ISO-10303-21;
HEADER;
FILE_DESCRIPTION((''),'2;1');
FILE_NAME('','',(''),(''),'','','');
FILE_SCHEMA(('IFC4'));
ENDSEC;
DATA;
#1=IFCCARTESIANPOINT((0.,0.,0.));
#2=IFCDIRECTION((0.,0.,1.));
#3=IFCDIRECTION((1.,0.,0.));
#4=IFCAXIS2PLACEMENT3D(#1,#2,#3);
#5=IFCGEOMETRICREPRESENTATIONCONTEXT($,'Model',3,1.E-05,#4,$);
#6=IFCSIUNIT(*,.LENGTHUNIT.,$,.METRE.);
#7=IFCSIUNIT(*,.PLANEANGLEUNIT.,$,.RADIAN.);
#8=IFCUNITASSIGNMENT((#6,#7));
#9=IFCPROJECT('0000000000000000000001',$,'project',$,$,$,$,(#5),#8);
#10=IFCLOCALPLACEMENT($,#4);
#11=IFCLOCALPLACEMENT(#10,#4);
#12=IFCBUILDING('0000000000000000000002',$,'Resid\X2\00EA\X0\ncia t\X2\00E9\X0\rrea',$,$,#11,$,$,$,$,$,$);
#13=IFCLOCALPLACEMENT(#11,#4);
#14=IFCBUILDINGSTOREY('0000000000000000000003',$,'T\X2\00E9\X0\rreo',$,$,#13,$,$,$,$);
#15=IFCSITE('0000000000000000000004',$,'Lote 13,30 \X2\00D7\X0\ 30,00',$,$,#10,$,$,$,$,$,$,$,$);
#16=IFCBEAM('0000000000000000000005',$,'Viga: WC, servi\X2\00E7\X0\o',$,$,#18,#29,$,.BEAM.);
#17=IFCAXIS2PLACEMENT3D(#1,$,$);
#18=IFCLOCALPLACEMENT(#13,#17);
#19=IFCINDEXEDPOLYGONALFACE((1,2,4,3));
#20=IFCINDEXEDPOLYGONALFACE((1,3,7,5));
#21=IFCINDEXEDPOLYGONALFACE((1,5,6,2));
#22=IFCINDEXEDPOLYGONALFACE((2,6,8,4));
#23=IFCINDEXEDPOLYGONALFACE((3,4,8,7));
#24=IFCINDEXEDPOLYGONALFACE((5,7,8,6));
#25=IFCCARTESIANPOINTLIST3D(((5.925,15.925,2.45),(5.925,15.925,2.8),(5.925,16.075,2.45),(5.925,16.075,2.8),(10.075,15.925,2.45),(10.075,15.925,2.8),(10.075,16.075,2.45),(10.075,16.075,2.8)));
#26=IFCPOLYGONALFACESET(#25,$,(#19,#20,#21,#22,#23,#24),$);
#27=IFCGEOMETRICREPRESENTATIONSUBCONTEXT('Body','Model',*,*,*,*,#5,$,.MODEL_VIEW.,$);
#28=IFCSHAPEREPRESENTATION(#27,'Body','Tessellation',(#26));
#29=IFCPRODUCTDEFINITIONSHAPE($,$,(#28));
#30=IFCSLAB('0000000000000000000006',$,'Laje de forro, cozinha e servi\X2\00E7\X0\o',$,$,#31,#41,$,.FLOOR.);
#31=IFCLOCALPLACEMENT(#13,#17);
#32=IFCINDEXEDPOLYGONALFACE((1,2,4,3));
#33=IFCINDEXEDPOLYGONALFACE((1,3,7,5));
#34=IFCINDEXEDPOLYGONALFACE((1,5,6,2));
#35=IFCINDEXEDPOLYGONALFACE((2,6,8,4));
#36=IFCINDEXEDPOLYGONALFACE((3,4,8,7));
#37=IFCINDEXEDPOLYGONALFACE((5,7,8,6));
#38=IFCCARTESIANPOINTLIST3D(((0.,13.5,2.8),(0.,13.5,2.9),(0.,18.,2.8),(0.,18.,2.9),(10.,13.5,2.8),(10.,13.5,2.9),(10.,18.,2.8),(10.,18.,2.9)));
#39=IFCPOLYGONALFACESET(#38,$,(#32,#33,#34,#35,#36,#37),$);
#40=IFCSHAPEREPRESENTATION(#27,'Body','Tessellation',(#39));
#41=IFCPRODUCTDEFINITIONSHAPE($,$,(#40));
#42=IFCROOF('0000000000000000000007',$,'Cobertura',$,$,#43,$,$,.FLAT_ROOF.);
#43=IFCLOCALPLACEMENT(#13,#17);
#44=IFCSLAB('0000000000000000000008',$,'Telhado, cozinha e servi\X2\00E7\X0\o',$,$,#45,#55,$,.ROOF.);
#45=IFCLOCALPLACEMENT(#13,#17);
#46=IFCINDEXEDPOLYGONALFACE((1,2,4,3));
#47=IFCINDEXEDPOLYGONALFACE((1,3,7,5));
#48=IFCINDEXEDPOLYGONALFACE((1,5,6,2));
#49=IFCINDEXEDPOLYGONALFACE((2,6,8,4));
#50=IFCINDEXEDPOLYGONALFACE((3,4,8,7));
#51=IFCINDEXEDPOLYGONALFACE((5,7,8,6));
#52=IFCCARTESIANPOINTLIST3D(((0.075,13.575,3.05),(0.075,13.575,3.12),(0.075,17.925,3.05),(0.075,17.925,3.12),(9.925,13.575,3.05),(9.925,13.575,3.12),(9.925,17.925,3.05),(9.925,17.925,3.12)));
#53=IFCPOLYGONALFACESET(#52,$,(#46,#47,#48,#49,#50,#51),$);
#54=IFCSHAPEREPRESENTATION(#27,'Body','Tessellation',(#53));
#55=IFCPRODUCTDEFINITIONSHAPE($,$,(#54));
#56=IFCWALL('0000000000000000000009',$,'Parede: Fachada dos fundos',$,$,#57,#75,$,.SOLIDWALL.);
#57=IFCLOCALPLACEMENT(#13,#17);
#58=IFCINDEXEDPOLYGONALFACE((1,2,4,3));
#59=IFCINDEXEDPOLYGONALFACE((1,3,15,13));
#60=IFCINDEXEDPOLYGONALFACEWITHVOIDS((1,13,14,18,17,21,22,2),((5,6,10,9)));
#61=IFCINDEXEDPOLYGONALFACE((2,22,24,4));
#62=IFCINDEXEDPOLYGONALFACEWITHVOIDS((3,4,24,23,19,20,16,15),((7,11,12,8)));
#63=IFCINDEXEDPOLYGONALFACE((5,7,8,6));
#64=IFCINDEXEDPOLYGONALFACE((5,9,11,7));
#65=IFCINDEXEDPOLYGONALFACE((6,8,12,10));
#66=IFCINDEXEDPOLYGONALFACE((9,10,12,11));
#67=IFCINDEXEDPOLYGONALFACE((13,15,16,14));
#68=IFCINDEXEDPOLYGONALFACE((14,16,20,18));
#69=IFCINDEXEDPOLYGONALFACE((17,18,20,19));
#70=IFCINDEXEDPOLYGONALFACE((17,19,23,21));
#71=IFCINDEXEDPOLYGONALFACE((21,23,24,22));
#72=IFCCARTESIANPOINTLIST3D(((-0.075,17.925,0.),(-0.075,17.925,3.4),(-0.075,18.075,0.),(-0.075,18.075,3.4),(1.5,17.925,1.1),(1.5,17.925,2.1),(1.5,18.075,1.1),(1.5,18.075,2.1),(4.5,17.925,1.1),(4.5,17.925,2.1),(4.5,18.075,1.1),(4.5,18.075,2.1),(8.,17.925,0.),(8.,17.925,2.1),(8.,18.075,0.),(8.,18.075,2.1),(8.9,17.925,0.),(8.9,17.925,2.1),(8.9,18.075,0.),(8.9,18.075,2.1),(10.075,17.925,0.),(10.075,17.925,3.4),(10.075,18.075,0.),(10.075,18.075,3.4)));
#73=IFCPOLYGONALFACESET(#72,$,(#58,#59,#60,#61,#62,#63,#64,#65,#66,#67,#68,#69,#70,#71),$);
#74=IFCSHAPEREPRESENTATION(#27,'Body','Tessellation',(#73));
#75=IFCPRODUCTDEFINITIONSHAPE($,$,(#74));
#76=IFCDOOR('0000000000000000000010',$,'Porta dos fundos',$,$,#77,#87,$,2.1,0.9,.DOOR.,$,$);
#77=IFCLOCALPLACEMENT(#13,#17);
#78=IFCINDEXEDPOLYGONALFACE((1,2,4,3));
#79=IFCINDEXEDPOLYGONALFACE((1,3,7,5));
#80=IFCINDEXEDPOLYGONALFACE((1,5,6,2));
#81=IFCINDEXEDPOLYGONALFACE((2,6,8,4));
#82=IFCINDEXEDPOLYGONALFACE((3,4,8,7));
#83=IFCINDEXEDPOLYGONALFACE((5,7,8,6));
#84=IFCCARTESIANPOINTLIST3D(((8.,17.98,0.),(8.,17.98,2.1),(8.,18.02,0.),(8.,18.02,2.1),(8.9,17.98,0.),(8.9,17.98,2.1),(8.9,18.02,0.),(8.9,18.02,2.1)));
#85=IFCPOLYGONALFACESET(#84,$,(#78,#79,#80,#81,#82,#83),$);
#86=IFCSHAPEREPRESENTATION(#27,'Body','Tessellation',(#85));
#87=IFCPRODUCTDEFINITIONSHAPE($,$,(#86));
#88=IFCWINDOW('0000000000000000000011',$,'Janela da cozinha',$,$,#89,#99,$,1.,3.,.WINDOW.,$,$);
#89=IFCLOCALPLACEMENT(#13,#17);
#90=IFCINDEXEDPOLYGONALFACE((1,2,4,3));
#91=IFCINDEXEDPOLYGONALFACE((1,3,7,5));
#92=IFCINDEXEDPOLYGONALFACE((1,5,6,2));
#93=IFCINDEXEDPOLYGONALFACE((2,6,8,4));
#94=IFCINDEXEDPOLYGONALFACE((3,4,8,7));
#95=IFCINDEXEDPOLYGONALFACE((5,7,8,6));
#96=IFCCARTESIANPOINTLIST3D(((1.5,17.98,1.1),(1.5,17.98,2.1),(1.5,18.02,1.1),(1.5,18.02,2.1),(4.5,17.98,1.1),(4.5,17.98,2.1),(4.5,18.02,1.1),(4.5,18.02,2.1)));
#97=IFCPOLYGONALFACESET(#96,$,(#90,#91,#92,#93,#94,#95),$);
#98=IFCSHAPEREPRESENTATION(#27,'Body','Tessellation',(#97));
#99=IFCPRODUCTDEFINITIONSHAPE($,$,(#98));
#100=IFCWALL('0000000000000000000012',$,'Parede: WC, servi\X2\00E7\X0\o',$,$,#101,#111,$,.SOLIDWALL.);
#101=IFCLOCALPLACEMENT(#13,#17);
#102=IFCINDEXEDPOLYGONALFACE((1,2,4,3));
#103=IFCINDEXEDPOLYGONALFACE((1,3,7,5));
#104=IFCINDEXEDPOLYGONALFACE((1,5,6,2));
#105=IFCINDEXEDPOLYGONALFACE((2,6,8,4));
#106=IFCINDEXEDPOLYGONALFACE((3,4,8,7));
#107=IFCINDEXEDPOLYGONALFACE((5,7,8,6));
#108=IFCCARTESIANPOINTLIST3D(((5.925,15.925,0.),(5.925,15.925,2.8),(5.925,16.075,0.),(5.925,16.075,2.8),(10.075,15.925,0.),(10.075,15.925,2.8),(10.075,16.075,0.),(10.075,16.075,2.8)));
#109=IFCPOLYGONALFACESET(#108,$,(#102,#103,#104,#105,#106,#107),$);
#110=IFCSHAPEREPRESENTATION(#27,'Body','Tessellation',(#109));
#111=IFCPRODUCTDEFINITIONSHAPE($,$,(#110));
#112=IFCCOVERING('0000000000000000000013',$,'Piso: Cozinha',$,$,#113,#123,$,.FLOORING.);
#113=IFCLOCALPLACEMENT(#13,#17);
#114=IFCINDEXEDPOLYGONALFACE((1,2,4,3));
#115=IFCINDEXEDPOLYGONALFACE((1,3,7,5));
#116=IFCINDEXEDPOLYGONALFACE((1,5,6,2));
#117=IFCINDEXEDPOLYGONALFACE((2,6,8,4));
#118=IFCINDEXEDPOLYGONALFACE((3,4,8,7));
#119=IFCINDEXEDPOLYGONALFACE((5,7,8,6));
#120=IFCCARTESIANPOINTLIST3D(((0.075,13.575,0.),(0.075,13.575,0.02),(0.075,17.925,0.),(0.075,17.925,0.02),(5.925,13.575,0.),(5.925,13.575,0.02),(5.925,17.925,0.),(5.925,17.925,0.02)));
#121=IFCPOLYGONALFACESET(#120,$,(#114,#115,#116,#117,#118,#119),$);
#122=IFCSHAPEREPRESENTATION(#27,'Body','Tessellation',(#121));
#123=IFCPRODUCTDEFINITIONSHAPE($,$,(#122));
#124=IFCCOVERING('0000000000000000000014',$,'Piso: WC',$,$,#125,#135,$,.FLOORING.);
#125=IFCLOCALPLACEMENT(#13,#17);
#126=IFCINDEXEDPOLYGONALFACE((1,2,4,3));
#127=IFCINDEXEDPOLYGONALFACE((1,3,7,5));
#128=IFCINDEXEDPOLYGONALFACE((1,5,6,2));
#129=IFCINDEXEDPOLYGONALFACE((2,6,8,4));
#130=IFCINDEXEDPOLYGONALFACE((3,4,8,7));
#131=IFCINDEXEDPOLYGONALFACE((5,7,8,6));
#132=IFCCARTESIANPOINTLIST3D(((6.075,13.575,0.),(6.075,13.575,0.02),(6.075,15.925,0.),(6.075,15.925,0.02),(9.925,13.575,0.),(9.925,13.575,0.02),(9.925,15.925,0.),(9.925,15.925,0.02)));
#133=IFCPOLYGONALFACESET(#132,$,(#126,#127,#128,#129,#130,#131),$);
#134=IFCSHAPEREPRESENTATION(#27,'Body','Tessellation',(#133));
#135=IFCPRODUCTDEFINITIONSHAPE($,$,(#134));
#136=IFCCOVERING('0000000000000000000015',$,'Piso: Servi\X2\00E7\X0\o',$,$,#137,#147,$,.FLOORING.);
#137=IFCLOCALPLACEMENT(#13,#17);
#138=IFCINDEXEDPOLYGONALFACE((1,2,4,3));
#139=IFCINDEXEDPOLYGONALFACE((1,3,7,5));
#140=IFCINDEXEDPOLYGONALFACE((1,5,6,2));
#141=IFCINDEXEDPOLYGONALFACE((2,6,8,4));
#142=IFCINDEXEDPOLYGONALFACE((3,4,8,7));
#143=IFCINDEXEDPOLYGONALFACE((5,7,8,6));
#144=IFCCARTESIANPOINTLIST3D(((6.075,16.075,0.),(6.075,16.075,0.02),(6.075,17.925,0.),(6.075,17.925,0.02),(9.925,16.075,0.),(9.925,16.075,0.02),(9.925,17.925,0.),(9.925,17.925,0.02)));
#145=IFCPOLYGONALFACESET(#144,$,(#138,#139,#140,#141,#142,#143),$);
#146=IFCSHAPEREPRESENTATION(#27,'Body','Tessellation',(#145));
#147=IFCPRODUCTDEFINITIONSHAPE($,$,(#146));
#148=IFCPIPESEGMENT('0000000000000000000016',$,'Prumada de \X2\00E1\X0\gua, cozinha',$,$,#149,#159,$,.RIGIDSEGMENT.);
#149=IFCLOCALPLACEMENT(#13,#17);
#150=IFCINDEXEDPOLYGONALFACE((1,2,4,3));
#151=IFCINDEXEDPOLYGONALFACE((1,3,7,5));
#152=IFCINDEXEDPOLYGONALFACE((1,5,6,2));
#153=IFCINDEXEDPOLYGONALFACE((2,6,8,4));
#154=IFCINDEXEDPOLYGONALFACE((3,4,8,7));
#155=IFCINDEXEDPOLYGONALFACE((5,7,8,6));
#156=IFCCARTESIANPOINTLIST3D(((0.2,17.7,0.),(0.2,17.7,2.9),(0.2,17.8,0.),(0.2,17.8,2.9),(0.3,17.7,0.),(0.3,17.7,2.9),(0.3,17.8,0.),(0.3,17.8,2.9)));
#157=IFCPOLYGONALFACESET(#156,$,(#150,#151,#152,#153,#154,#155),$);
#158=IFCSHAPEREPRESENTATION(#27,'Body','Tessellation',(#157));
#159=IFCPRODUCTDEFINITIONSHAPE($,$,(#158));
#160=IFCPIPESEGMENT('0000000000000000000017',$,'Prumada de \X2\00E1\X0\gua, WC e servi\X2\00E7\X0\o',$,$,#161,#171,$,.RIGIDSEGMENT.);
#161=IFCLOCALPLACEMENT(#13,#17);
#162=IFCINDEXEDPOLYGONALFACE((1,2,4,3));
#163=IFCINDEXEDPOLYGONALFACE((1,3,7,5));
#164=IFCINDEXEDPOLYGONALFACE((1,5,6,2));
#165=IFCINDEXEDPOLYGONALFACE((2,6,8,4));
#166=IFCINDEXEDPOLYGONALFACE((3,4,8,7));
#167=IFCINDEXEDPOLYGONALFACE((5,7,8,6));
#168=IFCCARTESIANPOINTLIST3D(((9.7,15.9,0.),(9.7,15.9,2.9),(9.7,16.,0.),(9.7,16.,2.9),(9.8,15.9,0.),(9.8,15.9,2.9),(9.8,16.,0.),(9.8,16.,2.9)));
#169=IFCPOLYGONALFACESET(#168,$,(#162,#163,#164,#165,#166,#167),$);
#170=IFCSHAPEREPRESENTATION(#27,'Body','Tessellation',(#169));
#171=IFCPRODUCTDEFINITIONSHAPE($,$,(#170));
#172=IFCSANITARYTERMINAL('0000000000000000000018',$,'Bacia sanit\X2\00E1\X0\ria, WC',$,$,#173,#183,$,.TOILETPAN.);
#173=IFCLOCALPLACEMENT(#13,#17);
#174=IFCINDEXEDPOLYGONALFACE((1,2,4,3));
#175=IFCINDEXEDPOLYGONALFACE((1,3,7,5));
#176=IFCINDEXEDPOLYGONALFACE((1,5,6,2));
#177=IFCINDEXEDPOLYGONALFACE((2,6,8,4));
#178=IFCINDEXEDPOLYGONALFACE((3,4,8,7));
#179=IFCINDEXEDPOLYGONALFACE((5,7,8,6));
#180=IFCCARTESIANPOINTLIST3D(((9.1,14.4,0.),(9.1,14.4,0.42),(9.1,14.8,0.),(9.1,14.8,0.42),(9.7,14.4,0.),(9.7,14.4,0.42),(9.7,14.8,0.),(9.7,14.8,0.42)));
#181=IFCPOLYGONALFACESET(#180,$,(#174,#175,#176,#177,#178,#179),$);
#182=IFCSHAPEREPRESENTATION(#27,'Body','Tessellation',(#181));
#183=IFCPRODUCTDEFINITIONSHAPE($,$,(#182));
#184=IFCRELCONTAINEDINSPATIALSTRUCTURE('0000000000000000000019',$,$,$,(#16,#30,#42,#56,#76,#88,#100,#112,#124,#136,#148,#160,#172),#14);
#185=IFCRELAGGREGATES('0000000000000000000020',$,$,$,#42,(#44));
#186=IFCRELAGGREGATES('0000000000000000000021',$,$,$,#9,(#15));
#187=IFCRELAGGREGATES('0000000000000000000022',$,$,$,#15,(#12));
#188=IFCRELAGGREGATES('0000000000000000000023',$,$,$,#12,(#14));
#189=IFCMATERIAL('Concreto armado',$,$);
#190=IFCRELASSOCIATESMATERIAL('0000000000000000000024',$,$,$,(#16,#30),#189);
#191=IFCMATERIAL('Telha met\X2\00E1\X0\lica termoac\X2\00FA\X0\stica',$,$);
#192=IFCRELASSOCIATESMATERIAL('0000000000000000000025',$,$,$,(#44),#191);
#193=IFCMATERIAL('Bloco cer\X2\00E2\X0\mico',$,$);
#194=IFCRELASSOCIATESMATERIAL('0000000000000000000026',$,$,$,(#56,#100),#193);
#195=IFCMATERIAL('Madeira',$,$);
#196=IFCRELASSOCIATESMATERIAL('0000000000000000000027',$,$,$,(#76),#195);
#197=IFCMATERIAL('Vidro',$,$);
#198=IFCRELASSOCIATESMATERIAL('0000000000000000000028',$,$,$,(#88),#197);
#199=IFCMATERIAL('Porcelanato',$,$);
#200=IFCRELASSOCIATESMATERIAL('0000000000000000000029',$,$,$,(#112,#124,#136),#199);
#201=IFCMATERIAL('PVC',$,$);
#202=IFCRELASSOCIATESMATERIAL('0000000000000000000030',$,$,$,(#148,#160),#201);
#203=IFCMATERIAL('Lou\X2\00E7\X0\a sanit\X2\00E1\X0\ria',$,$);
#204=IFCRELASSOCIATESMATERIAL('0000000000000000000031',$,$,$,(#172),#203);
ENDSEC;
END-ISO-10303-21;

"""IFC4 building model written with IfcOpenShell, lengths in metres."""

from ifc_helpers import new_model, si_unit, frame, origin_with_axes, place, context, subcontext, project, spatial, line, indexed_curve, outline, extrude, material, element, fill, aggregate, save


model = new_model("IFC4")

# Units and contexts
model_context = context("Model", 3, precision=1e-05, world=origin_with_axes())
body_context = subcontext(model_context, "Body", "Model", "MODEL_VIEW")
ifc_project = project(units=[si_unit("LENGTHUNIT", "METRE"), si_unit("PLANEANGLEUNIT", "RADIAN")], contexts=[model_context])

# Site, building, storey
site_placement = place(None, origin_with_axes())
site = spatial("IfcSite", under=ifc_project, at=site_placement, Name="Lote 13,30 × 30,00")
building_placement = place(site_placement, origin_with_axes())
building = spatial("IfcBuilding", under=site, at=building_placement, Name="Residência térrea")
storey_placement = place(building_placement, origin_with_axes())
storey = spatial("IfcBuildingStorey", under=building, at=storey_placement, Name="Térreo")

# Shared definitions
ifc_material_1 = material(Name="Concreto armado")

# Beam
beam_1_placement = place(storey_placement, frame((5.925, 15.925, 2.45), z_axis=(0.0, 0.0, 1.0), x_axis=(1.0, 0.0, 0.0)))
element("IfcBeam", 1, at=beam_1_placement, inside=storey, material=ifc_material_1, Name="Viga: WC, serviço", PredefinedType="BEAM", context=body_context, shape_type="SweptSolid", body=[
    extrude(outline(indexed_curve([(0.0, 0.0), (4.15, 0.0), (4.15, 0.15), (0.0, 0.15)], segments=[line(1, 2, 3, 4, 1)])), origin_with_axes(), (0.0, 0.0, 1.0), 0.35),
])

# Slab
slab_1_placement = place(storey_placement, frame((0.0, 13.5, 2.8), z_axis=(0.0, 0.0, 1.0), x_axis=(1.0, 0.0, 0.0)))
element("IfcSlab", 2, at=slab_1_placement, inside=storey, material=ifc_material_1, Name="Laje de forro, cozinha e serviço", PredefinedType="FLOOR", context=body_context, shape_type="SweptSolid", body=[
    extrude(outline(indexed_curve([(0.0, 0.0), (10.0, 0.0), (10.0, 4.5), (0.0, 4.5)], segments=[line(1, 2, 3, 4, 1)])), origin_with_axes(), (0.0, 0.0, 1.0), 0.1),
])

# Roof, slab
roof_placement = place(storey_placement, origin_with_axes())
roof = element("IfcRoof", 3, at=roof_placement, inside=storey, Name="Cobertura", PredefinedType="FLAT_ROOF")
ifc_material_2 = material(Name="Telha metálica termoacústica")
slab_2_placement = place(roof_placement, frame((0.075, 13.575, 3.05), z_axis=(0.0, 0.0, 1.0), x_axis=(1.0, 0.0, 0.0)))
slab_2 = element("IfcSlab", 4, at=slab_2_placement, material=ifc_material_2, Name="Telhado, cozinha e serviço", PredefinedType="ROOF", context=body_context, shape_type="SweptSolid", body=[
    extrude(outline(indexed_curve([(0.0, 0.0), (9.85, 0.0), (9.85, 4.35), (0.0, 4.35)], segments=[line(1, 2, 3, 4, 1)])), origin_with_axes(), (0.0, 0.0, 1.0), 0.07),
])
aggregate(roof, [slab_2])

# Wall, openings, door, window
ifc_material_3 = material(Name="Bloco cerâmico")
wall_1_placement = place(storey_placement, frame((-0.075, 17.925, 0.0), z_axis=(0.0, 0.0, 1.0), x_axis=(1.0, 0.0, 0.0)))
wall_1 = element("IfcWall", 5, at=wall_1_placement, inside=storey, material=ifc_material_3, Name="Parede: Fachada dos fundos", PredefinedType="SOLIDWALL", context=body_context, shape_type="SweptSolid", body=[
    extrude(outline(indexed_curve([(0.0, 0.0), (10.15, 0.0), (10.15, 0.15), (0.0, 0.15)], segments=[line(1, 2, 3, 4, 1)])), origin_with_axes(), (0.0, 0.0, 1.0), 3.4),
])
opening_1_placement = place(wall_1_placement, frame((8.075, -0.05, 0.0), z_axis=(0.0, 0.0, 1.0), x_axis=(1.0, 0.0, 0.0)))
opening_1 = element("IfcOpeningElement", 6, at=opening_1_placement, cuts=wall_1, material=ifc_material_1, PredefinedType="OPENING", context=body_context, shape_type="SweptSolid", body=[
    extrude(outline(indexed_curve([(0.0, 0.0), (0.9, 0.0), (0.9, 0.25), (0.0, 0.25)], segments=[line(1, 2, 3, 4, 1)])), origin_with_axes(), (0.0, 0.0, 1.0), 2.1),
])
opening_2_placement = place(wall_1_placement, frame((1.575, -0.05, 1.1), z_axis=(0.0, 0.0, 1.0), x_axis=(1.0, 0.0, 0.0)))
opening_2 = element("IfcOpeningElement", 7, at=opening_2_placement, cuts=wall_1, material=ifc_material_1, PredefinedType="OPENING", context=body_context, shape_type="SweptSolid", body=[
    extrude(outline(indexed_curve([(0.0, 0.0), (3.0, 0.0), (3.0, 0.25), (0.0, 0.25)], segments=[line(1, 2, 3, 4, 1)])), origin_with_axes(), (0.0, 0.0, 1.0), 1.0),
])
ifc_material_4 = material(Name="Madeira")
door_placement = place(storey_placement, frame((8.0, 17.98, 0.0), z_axis=(0.0, 0.0, 1.0), x_axis=(1.0, 0.0, 0.0)))
door = element("IfcDoor", 8, at=door_placement, inside=storey, material=ifc_material_4, Name="Porta dos fundos", OverallHeight=2.1, OverallWidth=0.9, PredefinedType="DOOR", context=body_context, shape_type="SweptSolid", body=[
    extrude(outline(indexed_curve([(0.0, 0.0), (0.9, 0.0), (0.9, 0.04), (0.0, 0.04)], segments=[line(1, 2, 3, 4, 1)])), origin_with_axes(), (0.0, 0.0, 1.0), 2.1),
])
fill(opening_1, door)
ifc_material_5 = material(Name="Vidro")
window_placement = place(storey_placement, frame((1.5, 17.98, 1.1), z_axis=(0.0, 0.0, 1.0), x_axis=(1.0, 0.0, 0.0)))
window = element("IfcWindow", 9, at=window_placement, inside=storey, material=ifc_material_5, Name="Janela da cozinha", OverallHeight=1.0, OverallWidth=3.0, PredefinedType="WINDOW", context=body_context, shape_type="SweptSolid", body=[
    extrude(outline(indexed_curve([(0.0, 0.0), (3.0, 0.0), (3.0, 0.04), (0.0, 0.04)], segments=[line(1, 2, 3, 4, 1)])), origin_with_axes(), (0.0, 0.0, 1.0), 1.0),
])
fill(opening_2, window)

# Wall
wall_2_placement = place(storey_placement, frame((5.925, 15.925, 0.0), z_axis=(0.0, 0.0, 1.0), x_axis=(1.0, 0.0, 0.0)))
element("IfcWall", 10, at=wall_2_placement, inside=storey, material=ifc_material_3, Name="Parede: WC, serviço", PredefinedType="SOLIDWALL", context=body_context, shape_type="SweptSolid", body=[
    extrude(outline(indexed_curve([(0.0, 0.0), (4.15, 0.0), (4.15, 0.15), (0.0, 0.15)], segments=[line(1, 2, 3, 4, 1)])), origin_with_axes(), (0.0, 0.0, 1.0), 2.8),
])

# Coverings
ifc_material_6 = material(Name="Porcelanato")
covering_1_placement = place(storey_placement, frame((0.075, 13.575, 0.0), z_axis=(0.0, 0.0, 1.0), x_axis=(1.0, 0.0, 0.0)))
element("IfcCovering", 11, at=covering_1_placement, inside=storey, material=ifc_material_6, Name="Piso: Cozinha", PredefinedType="FLOORING", context=body_context, shape_type="SweptSolid", body=[
    extrude(outline(indexed_curve([(0.0, 0.0), (5.85, 0.0), (5.85, 4.35), (0.0, 4.35)], segments=[line(1, 2, 3, 4, 1)])), origin_with_axes(), (0.0, 0.0, 1.0), 0.02),
])
covering_2_placement = place(storey_placement, frame((6.075, 13.575, 0.0), z_axis=(0.0, 0.0, 1.0), x_axis=(1.0, 0.0, 0.0)))
element("IfcCovering", 12, at=covering_2_placement, inside=storey, material=ifc_material_6, Name="Piso: WC", PredefinedType="FLOORING", context=body_context, shape_type="SweptSolid", body=[
    extrude(outline(indexed_curve([(0.0, 0.0), (3.85, 0.0), (3.85, 2.35), (0.0, 2.35)], segments=[line(1, 2, 3, 4, 1)])), origin_with_axes(), (0.0, 0.0, 1.0), 0.02),
])
covering_3_placement = place(storey_placement, frame((6.075, 16.075, 0.0), z_axis=(0.0, 0.0, 1.0), x_axis=(1.0, 0.0, 0.0)))
element("IfcCovering", 13, at=covering_3_placement, inside=storey, material=ifc_material_6, Name="Piso: Serviço", PredefinedType="FLOORING", context=body_context, shape_type="SweptSolid", body=[
    extrude(outline(indexed_curve([(0.0, 0.0), (3.85, 0.0), (3.85, 1.85), (0.0, 1.85)], segments=[line(1, 2, 3, 4, 1)])), origin_with_axes(), (0.0, 0.0, 1.0), 0.02),
])

# Pipe segments
ifc_material_7 = material(Name="PVC")
pipe_segment_1_placement = place(storey_placement, frame((0.2, 17.7, 0.0), z_axis=(0.0, 0.0, 1.0), x_axis=(1.0, 0.0, 0.0)))
element("IfcPipeSegment", 14, at=pipe_segment_1_placement, inside=storey, material=ifc_material_7, Name="Prumada de água, cozinha", PredefinedType="RIGIDSEGMENT", context=body_context, shape_type="SweptSolid", body=[
    extrude(outline(indexed_curve([(0.0, 0.0), (0.1, 0.0), (0.1, 0.1), (0.0, 0.1)], segments=[line(1, 2, 3, 4, 1)])), origin_with_axes(), (0.0, 0.0, 1.0), 2.9),
])
pipe_segment_2_placement = place(storey_placement, frame((9.7, 15.9, 0.0), z_axis=(0.0, 0.0, 1.0), x_axis=(1.0, 0.0, 0.0)))
element("IfcPipeSegment", 15, at=pipe_segment_2_placement, inside=storey, material=ifc_material_7, Name="Prumada de água, WC e serviço", PredefinedType="RIGIDSEGMENT", context=body_context, shape_type="SweptSolid", body=[
    extrude(outline(indexed_curve([(0.0, 0.0), (0.1, 0.0), (0.1, 0.1), (0.0, 0.1)], segments=[line(1, 2, 3, 4, 1)])), origin_with_axes(), (0.0, 0.0, 1.0), 2.9),
])

# Sanitary terminal
ifc_material_8 = material(Name="Louça sanitária")
sanitary_terminal_1_placement = place(storey_placement, frame((9.1, 14.4, 0.0), z_axis=(0.0, 0.0, 1.0), x_axis=(1.0, 0.0, 0.0)))
element("IfcSanitaryTerminal", 16, at=sanitary_terminal_1_placement, inside=storey, material=ifc_material_8, Name="Bacia sanitária, WC", PredefinedType="TOILETPAN", context=body_context, shape_type="SweptSolid", body=[
    extrude(outline(indexed_curve([(0.0, 0.0), (0.6, 0.0), (0.6, 0.4), (0.0, 0.4)], segments=[line(1, 2, 3, 4, 1)])), origin_with_axes(), (0.0, 0.0, 1.0), 0.42),
])

save(model, "model.ifc")
